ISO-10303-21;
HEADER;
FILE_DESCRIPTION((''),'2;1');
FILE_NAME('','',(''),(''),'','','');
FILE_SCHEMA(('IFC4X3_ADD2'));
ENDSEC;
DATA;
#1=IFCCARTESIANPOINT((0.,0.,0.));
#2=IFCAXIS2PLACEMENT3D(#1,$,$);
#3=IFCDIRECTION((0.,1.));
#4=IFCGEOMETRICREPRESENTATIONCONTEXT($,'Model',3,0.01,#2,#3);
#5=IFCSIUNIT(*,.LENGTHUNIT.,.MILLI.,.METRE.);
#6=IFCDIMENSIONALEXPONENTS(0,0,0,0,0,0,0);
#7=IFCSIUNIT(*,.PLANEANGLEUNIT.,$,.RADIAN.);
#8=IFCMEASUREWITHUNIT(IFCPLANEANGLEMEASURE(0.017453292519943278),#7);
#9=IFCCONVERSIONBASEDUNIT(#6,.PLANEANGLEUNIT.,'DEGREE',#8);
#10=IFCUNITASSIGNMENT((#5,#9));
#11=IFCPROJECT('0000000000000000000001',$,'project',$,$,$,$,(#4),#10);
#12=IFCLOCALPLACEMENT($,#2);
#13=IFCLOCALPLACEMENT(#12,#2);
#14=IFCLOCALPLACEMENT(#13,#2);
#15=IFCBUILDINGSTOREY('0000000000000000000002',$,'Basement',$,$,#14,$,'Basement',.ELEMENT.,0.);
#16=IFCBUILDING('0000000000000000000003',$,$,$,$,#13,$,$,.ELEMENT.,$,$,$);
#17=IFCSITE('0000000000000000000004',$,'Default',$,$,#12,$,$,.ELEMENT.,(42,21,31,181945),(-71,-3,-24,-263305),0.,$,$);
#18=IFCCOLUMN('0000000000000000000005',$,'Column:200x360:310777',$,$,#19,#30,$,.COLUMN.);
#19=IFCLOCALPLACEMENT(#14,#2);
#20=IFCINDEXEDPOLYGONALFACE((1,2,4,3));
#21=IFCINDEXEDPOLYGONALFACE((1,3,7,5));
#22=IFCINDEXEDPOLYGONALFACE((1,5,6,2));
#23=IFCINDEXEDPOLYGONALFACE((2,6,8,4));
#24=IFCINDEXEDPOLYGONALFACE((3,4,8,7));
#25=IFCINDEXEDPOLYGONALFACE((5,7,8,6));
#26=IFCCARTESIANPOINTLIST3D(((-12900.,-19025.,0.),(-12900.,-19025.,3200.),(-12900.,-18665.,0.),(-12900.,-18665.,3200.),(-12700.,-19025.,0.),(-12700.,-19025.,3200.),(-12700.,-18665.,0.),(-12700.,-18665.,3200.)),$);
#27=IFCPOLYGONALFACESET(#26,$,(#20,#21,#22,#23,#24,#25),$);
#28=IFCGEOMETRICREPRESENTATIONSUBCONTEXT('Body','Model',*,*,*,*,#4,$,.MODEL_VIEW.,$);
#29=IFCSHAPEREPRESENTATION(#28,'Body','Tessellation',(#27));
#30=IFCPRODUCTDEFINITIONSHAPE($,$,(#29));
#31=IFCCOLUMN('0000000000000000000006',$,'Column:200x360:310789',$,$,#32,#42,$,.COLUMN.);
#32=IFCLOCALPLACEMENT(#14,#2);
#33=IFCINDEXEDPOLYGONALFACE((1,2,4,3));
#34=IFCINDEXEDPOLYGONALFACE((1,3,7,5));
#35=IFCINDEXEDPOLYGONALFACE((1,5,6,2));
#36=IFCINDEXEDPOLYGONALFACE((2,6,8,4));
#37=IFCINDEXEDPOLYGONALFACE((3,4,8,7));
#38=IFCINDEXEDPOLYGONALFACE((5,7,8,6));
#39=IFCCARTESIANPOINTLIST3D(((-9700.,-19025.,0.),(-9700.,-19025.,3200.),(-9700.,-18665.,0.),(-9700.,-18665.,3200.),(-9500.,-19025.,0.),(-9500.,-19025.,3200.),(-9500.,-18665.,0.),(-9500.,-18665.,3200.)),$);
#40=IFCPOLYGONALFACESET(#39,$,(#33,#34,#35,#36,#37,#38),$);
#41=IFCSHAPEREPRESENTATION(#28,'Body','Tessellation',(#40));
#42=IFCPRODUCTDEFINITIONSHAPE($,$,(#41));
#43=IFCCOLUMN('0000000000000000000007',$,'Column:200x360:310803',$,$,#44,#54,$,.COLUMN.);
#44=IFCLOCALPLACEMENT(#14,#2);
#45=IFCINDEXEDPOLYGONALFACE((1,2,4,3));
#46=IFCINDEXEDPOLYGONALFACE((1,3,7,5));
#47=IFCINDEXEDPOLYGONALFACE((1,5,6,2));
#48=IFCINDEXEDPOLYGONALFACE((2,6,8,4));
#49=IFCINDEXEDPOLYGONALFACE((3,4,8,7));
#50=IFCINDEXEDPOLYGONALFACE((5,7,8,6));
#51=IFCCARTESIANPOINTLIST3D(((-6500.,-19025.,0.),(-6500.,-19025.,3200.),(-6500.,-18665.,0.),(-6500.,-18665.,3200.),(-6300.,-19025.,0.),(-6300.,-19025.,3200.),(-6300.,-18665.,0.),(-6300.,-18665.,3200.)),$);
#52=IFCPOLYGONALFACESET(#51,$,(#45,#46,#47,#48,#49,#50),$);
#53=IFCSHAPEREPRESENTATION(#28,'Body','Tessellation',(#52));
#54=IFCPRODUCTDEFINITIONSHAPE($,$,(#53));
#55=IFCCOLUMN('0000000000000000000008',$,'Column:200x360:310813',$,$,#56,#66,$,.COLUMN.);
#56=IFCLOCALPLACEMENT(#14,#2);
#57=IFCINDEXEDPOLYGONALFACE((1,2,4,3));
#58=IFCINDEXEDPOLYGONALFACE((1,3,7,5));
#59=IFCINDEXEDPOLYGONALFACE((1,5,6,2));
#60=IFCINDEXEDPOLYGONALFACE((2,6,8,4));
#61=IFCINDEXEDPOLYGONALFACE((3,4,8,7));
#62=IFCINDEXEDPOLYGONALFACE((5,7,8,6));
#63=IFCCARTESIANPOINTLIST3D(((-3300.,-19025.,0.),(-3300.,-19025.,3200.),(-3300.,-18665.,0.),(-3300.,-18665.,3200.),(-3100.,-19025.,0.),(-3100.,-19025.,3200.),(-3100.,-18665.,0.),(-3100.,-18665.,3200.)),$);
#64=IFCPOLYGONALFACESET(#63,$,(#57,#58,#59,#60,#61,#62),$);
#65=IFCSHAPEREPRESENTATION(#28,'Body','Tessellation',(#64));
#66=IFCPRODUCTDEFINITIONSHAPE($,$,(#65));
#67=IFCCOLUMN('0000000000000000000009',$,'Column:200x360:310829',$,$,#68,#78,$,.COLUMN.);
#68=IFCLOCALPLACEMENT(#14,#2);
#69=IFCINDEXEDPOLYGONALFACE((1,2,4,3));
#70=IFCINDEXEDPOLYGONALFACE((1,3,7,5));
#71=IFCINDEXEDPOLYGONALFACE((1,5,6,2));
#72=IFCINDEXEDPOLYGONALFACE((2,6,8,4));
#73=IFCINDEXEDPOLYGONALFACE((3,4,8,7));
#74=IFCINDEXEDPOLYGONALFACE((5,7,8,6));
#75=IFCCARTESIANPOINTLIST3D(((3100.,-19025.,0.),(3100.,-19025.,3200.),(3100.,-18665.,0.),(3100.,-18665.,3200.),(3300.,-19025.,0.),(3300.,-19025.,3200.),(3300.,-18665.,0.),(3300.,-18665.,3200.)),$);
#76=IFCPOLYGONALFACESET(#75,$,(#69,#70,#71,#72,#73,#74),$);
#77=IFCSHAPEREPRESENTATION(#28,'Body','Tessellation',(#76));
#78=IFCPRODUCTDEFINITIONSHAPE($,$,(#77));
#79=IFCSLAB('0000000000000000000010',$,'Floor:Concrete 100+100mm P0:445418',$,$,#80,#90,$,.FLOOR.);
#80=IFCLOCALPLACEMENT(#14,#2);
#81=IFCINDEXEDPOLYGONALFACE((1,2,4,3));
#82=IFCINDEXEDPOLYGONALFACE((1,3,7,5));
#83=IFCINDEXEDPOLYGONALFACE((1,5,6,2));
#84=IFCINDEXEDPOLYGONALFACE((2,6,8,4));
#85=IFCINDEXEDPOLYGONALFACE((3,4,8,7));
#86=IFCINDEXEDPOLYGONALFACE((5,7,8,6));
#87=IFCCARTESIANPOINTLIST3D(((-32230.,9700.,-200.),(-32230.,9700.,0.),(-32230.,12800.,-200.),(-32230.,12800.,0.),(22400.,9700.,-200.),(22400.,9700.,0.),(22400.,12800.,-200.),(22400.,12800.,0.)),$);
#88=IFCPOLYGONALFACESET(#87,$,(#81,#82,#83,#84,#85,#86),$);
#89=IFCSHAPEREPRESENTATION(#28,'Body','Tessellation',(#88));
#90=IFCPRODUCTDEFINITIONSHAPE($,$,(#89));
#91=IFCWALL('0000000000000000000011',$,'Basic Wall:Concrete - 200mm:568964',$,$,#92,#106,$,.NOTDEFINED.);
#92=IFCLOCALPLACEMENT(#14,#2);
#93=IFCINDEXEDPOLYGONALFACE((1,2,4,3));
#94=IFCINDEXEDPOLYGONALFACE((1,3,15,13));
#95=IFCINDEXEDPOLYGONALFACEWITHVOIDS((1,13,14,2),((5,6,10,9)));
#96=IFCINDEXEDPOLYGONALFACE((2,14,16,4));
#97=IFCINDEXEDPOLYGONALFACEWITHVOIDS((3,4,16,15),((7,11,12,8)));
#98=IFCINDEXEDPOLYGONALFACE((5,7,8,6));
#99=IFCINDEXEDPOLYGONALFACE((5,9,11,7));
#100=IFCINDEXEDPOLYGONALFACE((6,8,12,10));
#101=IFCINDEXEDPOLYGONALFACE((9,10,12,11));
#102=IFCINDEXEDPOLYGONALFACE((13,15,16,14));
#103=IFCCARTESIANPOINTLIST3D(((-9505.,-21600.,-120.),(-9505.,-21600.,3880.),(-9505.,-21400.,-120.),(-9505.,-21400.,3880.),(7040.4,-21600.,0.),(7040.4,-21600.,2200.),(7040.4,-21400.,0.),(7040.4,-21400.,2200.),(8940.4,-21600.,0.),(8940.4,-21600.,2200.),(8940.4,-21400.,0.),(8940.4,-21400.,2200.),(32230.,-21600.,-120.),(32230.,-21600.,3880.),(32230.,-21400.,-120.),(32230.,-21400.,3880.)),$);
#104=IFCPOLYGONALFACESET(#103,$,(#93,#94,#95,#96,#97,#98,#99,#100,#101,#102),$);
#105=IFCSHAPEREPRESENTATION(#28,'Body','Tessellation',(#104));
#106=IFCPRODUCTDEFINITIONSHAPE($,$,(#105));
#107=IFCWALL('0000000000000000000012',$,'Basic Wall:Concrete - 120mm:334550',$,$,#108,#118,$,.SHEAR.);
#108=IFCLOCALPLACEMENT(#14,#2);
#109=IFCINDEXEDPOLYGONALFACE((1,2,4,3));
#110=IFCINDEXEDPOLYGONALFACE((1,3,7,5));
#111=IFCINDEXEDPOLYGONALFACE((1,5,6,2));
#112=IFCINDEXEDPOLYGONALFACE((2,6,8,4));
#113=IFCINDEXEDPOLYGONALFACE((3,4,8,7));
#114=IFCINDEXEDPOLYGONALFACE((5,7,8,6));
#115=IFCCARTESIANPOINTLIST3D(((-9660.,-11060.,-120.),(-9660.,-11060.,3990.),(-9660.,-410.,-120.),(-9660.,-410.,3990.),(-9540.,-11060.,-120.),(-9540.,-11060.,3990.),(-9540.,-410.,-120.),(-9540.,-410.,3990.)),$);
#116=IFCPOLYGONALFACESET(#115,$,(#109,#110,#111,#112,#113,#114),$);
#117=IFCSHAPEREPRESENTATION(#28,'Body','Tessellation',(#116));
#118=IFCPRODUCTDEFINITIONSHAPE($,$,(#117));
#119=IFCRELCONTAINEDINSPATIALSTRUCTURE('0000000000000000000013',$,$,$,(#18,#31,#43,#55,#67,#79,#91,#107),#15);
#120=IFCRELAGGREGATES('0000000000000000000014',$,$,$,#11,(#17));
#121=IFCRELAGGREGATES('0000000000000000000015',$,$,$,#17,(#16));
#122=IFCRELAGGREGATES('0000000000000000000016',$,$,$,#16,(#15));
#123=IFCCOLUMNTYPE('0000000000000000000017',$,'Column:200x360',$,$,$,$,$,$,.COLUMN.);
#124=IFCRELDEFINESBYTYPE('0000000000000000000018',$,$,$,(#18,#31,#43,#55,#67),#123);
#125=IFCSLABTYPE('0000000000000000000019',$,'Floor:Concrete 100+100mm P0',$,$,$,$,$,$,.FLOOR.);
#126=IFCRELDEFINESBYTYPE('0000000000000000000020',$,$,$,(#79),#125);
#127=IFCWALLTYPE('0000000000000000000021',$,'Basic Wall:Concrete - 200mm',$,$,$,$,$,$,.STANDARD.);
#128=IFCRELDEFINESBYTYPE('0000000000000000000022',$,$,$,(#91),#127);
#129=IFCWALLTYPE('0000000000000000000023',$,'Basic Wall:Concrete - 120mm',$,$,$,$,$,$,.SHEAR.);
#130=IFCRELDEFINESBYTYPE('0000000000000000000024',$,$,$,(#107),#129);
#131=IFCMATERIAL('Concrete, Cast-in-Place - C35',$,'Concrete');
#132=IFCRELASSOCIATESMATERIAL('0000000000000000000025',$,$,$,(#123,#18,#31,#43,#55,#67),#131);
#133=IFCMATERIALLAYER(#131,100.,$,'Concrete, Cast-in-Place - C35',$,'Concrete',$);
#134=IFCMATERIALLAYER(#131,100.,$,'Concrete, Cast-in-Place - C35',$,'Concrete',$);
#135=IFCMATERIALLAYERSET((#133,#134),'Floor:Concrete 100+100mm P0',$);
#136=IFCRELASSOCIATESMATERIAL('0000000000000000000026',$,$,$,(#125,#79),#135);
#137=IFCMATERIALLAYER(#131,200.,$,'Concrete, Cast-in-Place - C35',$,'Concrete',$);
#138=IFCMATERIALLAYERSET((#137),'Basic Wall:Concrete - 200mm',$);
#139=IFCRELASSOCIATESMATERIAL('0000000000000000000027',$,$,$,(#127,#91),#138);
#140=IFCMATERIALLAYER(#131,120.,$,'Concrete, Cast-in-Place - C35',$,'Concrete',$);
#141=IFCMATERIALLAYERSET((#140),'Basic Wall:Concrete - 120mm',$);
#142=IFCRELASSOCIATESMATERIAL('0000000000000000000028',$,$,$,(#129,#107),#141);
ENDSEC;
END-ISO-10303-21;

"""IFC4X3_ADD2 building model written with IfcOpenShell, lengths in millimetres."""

from ifc_helpers import new_model, entity, si_unit, converted_unit, direction, frame, frame_2d, origin, origin_2d_with_axis, place, context, subcontext, project, spatial, rectangle, extrude, source, transform, mapped, material, layer, layer_set, layer_usage, material_profile, profile_set, profile_usage, type_object, type_shapes, element, save


model = new_model("IFC4X3_ADD2")

# Units and contexts
model_context = context("Model", 3, precision=0.01, world=origin(), true_north=direction((0.0, 1.0)))
body_context = subcontext(model_context, "Body", "Model", "MODEL_VIEW")
ifc_project = project(units=[si_unit("LENGTHUNIT", "METRE", prefix="MILLI"), converted_unit("PLANEANGLEUNIT", "DEGREE", entity("IfcPlaneAngleMeasure", 0.017453292519943278), si_unit("PLANEANGLEUNIT", "RADIAN"), dimensions=[0, 0, 0, 0, 0, 0, 0])], contexts=[model_context])

# Site, building, storey
site_placement = place(None, origin())
site = spatial("IfcSite", under=ifc_project, at=site_placement, Name="Default", CompositionType="ELEMENT", RefLatitude=(42, 21, 31, 181945), RefLongitude=(-71, -3, -24, -263305), RefElevation=0.0)
building_placement = place(site_placement, origin())
building = spatial("IfcBuilding", under=site, at=building_placement, CompositionType="ELEMENT")
storey_placement = place(building_placement, origin())
storey = spatial("IfcBuildingStorey", under=building, at=storey_placement, Name="Basement", LongName="Basement", CompositionType="ELEMENT", Elevation=0.0)

# Columns
ifc_material = material(Name="Concrete, Cast-in-Place - C35", Category="Concrete")
ifc_material_profile_1 = material_profile(ifc_material, rectangle(XDim=200.0, YDim=360.0, at=origin_2d_with_axis()), Name="200x360")
ifc_profile_set_1 = profile_set([ifc_material_profile_1], Name="200x360")
ifc_profile_usage_1 = profile_usage(ifc_profile_set_1)
column_type_1 = type_object("IfcColumnType", Name="Column:200x360", PredefinedType="COLUMN", material=ifc_profile_set_1)
shared_shape_1 = source(origin(), body_context, "Body", "SweptSolid", [
    extrude(rectangle(XDim=200.0, YDim=360.0, at=origin_2d_with_axis()), frame((0.0, 80.0, 0.0), z_axis=(0.0, 0.0, 1.0), x_axis=(-1.0, 0.0, 0.0)), (0.0, 0.0, 1.0), 3200.0),
])
type_shapes(column_type_1, [shared_shape_1])
for number, where, name in (
    (1, (-12800.0, -18925.0, 0.0), "Column:200x360:310777"),
    (2, (-9600.0, -18925.0, 0.0), "Column:200x360:310789"),
    (3, (-6400.0, -18925.0, 0.0), "Column:200x360:310803"),
    (4, (-3200.0, -18925.0, 0.0), "Column:200x360:310813"),
    (5, (3200.0, -18925.0, 0.0), "Column:200x360:310829"),
):
    element("IfcColumn", number, at=place(storey_placement, frame(where)), inside=storey, type_object=column_type_1, material=ifc_profile_usage_1, Name=name, PredefinedType="COLUMN", context=body_context, shape_type="MappedRepresentation", body=[
        mapped(shared_shape_1, transform((0.0, 0.0, 0.0), scale=1.0)),
    ])

# Slab
ifc_layer_1 = layer(ifc_material, 100.0, Name="Concrete, Cast-in-Place - C35", Category="Concrete")
ifc_layer_2 = layer(ifc_material, 100.0, Name="Concrete, Cast-in-Place - C35", Category="Concrete")
ifc_layer_set_1 = layer_set([ifc_layer_1, ifc_layer_2], Name="Floor:Concrete 100+100mm P0")
ifc_layer_usage_1 = layer_usage(ifc_layer_set_1, "AXIS3", "POSITIVE", 0.0)
slab_type_1 = type_object("IfcSlabType", Name="Floor:Concrete 100+100mm P0", PredefinedType="FLOOR", material=ifc_layer_set_1)
slab_1_placement = place(storey_placement, origin())
element("IfcSlab", 6, at=slab_1_placement, inside=storey, type_object=slab_type_1, material=ifc_layer_usage_1, Name="Floor:Concrete 100+100mm P0:445418", PredefinedType="FLOOR", context=body_context, shape_type="SweptSolid", body=[
    extrude(rectangle(XDim=3100.0, YDim=54630.0, at=frame_2d((0.0, 0.0), x_axis=(1.0, 0.0))), frame((-4915.0, 11250.0, 0.0), z_axis=(0.0, 0.0, -1.0), x_axis=(0.0, 1.0, 0.0)), (0.0, 0.0, 1.0), 200.0),
])

# Wall, opening
ifc_layer_3 = layer(ifc_material, 200.0, Name="Concrete, Cast-in-Place - C35", Category="Concrete")
ifc_layer_set_2 = layer_set([ifc_layer_3], Name="Basic Wall:Concrete - 200mm")
wall_type_1 = type_object("IfcWallType", Name="Basic Wall:Concrete - 200mm", PredefinedType="STANDARD", material=ifc_layer_set_2)
wall_1_placement = place(storey_placement, frame((-9505.0, -21500.0, -120.0)))
wall_1 = element("IfcWall", 7, at=wall_1_placement, inside=storey, type_object=wall_type_1, material=ifc_layer_set_2, Name="Basic Wall:Concrete - 200mm:568964", PredefinedType="NOTDEFINED", context=body_context, shape_type="SweptSolid", body=[
    extrude(rectangle(XDim=41735.0, YDim=200.0, at=frame_2d((20867.5, 0.0), x_axis=(-1.0, 0.0))), origin(), (0.0, 0.0, 1.0), 4000.0),
])
opening_placement = place(wall_1_placement, frame((16545.5, -100.0, 120.0)))
element("IfcOpeningElement", 8, at=opening_placement, cuts=wall_1, PredefinedType="OPENING", context=body_context, shape_type="SweptSolid", body=[
    extrude(rectangle(XDim=2200.0, YDim=1900.0, at=origin_2d_with_axis()), frame((950.0, 0.0, 1100.0), z_axis=(0.0, 1.0, 0.0), x_axis=(0.0, 0.0, -1.0)), (0.0, 0.0, 1.0), 200.0),
])

# Wall
ifc_layer_4 = layer(ifc_material, 120.0, Name="Concrete, Cast-in-Place - C35", Category="Concrete")
ifc_layer_set_3 = layer_set([ifc_layer_4], Name="Basic Wall:Concrete - 120mm")
wall_type_2 = type_object("IfcWallType", Name="Basic Wall:Concrete - 120mm", PredefinedType="SHEAR", material=ifc_layer_set_3)
wall_2_placement = place(storey_placement, frame((-9600.0, -410.0, -120.0), z_axis=(0.0, 0.0, 1.0), x_axis=(0.0, -1.0, 0.0)))
element("IfcWall", 9, at=wall_2_placement, inside=storey, type_object=wall_type_2, material=ifc_layer_set_3, Name="Basic Wall:Concrete - 120mm:334550", PredefinedType="SHEAR", context=body_context, shape_type="SweptSolid", body=[
    extrude(rectangle(XDim=10650.0, YDim=120.0, at=frame_2d((5325.0, 0.0), x_axis=(-1.0, 0.0))), origin(), (0.0, 0.0, 1.0), 4110.0),
])

save(model, "model.ifc")
